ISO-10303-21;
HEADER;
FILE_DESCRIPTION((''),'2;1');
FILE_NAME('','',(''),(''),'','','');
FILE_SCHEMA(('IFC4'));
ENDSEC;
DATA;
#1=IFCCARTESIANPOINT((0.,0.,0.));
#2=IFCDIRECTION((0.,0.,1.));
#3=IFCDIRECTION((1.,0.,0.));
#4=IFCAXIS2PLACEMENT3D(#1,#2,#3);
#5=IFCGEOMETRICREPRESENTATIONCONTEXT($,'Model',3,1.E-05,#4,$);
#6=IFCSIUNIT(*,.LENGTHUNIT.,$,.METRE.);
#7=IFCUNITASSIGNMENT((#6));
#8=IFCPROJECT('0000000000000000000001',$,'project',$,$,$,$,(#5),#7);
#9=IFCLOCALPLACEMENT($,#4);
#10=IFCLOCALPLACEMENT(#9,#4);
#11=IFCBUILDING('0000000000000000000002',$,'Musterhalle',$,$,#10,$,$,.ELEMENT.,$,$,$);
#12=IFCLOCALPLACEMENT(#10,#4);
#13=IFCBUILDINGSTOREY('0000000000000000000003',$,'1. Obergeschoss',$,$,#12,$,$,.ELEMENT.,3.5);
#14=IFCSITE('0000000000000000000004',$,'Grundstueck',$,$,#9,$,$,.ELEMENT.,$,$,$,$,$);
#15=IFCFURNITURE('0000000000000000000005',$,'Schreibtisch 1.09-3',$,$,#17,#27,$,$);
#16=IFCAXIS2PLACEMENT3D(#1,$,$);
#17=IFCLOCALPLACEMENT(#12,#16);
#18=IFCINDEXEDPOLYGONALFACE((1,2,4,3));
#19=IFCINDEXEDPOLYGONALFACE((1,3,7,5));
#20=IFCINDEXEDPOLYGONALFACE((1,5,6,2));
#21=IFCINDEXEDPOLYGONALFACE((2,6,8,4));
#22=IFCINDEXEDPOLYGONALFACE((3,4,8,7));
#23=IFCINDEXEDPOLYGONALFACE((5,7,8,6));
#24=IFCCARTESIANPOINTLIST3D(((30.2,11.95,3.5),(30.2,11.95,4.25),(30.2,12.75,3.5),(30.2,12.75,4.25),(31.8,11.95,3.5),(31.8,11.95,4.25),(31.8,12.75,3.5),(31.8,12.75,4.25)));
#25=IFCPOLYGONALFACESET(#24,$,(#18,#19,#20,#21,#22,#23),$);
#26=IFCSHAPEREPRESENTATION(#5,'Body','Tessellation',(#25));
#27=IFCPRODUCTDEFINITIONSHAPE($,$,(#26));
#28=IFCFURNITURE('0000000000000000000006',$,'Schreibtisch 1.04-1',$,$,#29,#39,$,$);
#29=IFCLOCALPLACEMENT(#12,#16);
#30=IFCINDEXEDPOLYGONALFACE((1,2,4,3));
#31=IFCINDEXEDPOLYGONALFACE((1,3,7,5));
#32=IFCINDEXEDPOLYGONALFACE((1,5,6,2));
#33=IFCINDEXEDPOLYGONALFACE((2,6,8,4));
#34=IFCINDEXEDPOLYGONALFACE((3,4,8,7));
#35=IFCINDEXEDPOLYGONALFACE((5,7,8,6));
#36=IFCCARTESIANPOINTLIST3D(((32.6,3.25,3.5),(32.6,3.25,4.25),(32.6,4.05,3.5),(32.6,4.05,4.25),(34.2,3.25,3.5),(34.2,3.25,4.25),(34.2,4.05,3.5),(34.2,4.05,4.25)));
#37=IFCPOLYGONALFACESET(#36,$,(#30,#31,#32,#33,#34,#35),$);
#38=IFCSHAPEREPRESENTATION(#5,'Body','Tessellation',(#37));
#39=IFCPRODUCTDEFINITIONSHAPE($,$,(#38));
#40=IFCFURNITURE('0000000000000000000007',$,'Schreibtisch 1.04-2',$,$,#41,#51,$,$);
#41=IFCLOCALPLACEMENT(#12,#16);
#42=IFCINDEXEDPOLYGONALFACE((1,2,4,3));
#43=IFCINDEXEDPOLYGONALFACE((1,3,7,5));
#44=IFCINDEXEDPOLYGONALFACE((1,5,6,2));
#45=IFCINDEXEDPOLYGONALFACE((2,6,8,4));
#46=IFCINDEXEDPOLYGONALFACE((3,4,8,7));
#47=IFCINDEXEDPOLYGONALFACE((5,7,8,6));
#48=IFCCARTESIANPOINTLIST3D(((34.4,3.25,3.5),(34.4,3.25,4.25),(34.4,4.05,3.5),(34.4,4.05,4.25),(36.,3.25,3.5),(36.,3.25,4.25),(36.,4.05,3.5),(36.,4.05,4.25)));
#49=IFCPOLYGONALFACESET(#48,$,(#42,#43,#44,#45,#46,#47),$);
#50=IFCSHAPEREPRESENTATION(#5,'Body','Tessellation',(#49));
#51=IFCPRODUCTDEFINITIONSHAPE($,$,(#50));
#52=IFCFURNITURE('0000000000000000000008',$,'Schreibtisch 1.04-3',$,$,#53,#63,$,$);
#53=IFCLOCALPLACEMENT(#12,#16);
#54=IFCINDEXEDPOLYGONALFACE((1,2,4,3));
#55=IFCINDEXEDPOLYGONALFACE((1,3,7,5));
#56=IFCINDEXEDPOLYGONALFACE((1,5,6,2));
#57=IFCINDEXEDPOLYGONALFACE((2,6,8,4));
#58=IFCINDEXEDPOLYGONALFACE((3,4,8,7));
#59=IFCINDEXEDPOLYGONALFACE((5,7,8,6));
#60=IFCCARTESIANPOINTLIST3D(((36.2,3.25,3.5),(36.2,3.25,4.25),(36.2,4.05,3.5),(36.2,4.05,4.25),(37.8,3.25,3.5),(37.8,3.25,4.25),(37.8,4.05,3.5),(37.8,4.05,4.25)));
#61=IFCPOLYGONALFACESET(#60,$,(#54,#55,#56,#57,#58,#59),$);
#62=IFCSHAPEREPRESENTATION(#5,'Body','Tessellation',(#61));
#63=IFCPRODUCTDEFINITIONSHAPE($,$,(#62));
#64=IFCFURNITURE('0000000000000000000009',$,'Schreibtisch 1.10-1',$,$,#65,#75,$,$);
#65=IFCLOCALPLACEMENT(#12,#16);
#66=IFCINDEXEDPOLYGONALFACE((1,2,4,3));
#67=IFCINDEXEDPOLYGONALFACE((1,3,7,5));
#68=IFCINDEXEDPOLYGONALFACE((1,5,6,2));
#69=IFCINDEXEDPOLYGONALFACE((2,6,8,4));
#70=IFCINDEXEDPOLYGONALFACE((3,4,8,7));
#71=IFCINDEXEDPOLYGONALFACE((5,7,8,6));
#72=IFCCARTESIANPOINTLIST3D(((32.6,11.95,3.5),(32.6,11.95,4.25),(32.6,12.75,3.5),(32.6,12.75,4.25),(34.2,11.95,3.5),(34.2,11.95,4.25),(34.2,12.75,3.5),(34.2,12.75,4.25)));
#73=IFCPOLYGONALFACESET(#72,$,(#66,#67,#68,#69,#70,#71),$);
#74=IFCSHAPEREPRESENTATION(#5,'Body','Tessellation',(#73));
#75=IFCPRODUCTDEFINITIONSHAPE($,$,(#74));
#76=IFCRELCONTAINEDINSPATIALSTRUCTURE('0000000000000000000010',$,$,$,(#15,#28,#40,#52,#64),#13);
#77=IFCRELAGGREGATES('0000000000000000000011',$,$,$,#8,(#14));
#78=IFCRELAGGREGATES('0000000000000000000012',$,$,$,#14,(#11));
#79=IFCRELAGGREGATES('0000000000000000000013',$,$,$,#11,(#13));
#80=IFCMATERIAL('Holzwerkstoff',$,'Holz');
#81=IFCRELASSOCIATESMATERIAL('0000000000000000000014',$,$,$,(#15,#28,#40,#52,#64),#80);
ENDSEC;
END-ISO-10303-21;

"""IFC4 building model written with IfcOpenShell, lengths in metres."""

from ifc_helpers import new_model, si_unit, frame, origin_with_axes, origin_2d, place, context, project, spatial, rectangle, extrude, material, element, save


model = new_model("IFC4")

# Units and contexts
model_context = context("Model", 3, precision=1e-05, world=origin_with_axes())
ifc_project = project(units=[si_unit("LENGTHUNIT", "METRE")], contexts=[model_context])

# Site, building, storey
site_placement = place(None, origin_with_axes())
site = spatial("IfcSite", under=ifc_project, at=site_placement, Name="Grundstueck", CompositionType="ELEMENT")
building_placement = place(site_placement, origin_with_axes())
building = spatial("IfcBuilding", under=site, at=building_placement, Name="Musterhalle", CompositionType="ELEMENT")
storey_placement = place(building_placement, origin_with_axes())
storey = spatial("IfcBuildingStorey", under=building, at=storey_placement, Name="1. Obergeschoss", CompositionType="ELEMENT", Elevation=3.5)

# Shared definitions
placement = place(storey_placement, origin_with_axes())

# Shared definitions
ifc_material_1 = material(Name="Holzwerkstoff", Category="Holz")

# Furniture
element("IfcFurniture", 1, at=placement, inside=storey, material=ifc_material_1, Name="Schreibtisch 1.09-3", context=model_context, shape_type="SweptSolid", body=[
    extrude(rectangle(XDim=1.6, YDim=0.8, at=origin_2d()), frame((31.0, 12.35, 3.5), z_axis=(0.0, 0.0, 1.0), x_axis=(1.0, 0.0, 0.0)), (0.0, 0.0, 1.0), 0.75),
])
element("IfcFurniture", 2, at=placement, inside=storey, material=ifc_material_1, Name="Schreibtisch 1.04-1", context=model_context, shape_type="SweptSolid", body=[
    extrude(rectangle(XDim=1.6, YDim=0.8, at=origin_2d()), frame((33.4, 3.65, 3.5), z_axis=(0.0, 0.0, 1.0), x_axis=(1.0, 0.0, 0.0)), (0.0, 0.0, 1.0), 0.75),
])
element("IfcFurniture", 3, at=placement, inside=storey, material=ifc_material_1, Name="Schreibtisch 1.04-2", context=model_context, shape_type="SweptSolid", body=[
    extrude(rectangle(XDim=1.6, YDim=0.8, at=origin_2d()), frame((35.2, 3.65, 3.5), z_axis=(0.0, 0.0, 1.0), x_axis=(1.0, 0.0, 0.0)), (0.0, 0.0, 1.0), 0.75),
])
element("IfcFurniture", 4, at=placement, inside=storey, material=ifc_material_1, Name="Schreibtisch 1.04-3", context=model_context, shape_type="SweptSolid", body=[
    extrude(rectangle(XDim=1.6, YDim=0.8, at=origin_2d()), frame((37.0, 3.65, 3.5), z_axis=(0.0, 0.0, 1.0), x_axis=(1.0, 0.0, 0.0)), (0.0, 0.0, 1.0), 0.75),
])
element("IfcFurniture", 5, at=placement, inside=storey, material=ifc_material_1, Name="Schreibtisch 1.10-1", context=model_context, shape_type="SweptSolid", body=[
    extrude(rectangle(XDim=1.6, YDim=0.8, at=origin_2d()), frame((33.4, 12.35, 3.5), z_axis=(0.0, 0.0, 1.0), x_axis=(1.0, 0.0, 0.0)), (0.0, 0.0, 1.0), 0.75),
])

save(model, "model.ifc")
